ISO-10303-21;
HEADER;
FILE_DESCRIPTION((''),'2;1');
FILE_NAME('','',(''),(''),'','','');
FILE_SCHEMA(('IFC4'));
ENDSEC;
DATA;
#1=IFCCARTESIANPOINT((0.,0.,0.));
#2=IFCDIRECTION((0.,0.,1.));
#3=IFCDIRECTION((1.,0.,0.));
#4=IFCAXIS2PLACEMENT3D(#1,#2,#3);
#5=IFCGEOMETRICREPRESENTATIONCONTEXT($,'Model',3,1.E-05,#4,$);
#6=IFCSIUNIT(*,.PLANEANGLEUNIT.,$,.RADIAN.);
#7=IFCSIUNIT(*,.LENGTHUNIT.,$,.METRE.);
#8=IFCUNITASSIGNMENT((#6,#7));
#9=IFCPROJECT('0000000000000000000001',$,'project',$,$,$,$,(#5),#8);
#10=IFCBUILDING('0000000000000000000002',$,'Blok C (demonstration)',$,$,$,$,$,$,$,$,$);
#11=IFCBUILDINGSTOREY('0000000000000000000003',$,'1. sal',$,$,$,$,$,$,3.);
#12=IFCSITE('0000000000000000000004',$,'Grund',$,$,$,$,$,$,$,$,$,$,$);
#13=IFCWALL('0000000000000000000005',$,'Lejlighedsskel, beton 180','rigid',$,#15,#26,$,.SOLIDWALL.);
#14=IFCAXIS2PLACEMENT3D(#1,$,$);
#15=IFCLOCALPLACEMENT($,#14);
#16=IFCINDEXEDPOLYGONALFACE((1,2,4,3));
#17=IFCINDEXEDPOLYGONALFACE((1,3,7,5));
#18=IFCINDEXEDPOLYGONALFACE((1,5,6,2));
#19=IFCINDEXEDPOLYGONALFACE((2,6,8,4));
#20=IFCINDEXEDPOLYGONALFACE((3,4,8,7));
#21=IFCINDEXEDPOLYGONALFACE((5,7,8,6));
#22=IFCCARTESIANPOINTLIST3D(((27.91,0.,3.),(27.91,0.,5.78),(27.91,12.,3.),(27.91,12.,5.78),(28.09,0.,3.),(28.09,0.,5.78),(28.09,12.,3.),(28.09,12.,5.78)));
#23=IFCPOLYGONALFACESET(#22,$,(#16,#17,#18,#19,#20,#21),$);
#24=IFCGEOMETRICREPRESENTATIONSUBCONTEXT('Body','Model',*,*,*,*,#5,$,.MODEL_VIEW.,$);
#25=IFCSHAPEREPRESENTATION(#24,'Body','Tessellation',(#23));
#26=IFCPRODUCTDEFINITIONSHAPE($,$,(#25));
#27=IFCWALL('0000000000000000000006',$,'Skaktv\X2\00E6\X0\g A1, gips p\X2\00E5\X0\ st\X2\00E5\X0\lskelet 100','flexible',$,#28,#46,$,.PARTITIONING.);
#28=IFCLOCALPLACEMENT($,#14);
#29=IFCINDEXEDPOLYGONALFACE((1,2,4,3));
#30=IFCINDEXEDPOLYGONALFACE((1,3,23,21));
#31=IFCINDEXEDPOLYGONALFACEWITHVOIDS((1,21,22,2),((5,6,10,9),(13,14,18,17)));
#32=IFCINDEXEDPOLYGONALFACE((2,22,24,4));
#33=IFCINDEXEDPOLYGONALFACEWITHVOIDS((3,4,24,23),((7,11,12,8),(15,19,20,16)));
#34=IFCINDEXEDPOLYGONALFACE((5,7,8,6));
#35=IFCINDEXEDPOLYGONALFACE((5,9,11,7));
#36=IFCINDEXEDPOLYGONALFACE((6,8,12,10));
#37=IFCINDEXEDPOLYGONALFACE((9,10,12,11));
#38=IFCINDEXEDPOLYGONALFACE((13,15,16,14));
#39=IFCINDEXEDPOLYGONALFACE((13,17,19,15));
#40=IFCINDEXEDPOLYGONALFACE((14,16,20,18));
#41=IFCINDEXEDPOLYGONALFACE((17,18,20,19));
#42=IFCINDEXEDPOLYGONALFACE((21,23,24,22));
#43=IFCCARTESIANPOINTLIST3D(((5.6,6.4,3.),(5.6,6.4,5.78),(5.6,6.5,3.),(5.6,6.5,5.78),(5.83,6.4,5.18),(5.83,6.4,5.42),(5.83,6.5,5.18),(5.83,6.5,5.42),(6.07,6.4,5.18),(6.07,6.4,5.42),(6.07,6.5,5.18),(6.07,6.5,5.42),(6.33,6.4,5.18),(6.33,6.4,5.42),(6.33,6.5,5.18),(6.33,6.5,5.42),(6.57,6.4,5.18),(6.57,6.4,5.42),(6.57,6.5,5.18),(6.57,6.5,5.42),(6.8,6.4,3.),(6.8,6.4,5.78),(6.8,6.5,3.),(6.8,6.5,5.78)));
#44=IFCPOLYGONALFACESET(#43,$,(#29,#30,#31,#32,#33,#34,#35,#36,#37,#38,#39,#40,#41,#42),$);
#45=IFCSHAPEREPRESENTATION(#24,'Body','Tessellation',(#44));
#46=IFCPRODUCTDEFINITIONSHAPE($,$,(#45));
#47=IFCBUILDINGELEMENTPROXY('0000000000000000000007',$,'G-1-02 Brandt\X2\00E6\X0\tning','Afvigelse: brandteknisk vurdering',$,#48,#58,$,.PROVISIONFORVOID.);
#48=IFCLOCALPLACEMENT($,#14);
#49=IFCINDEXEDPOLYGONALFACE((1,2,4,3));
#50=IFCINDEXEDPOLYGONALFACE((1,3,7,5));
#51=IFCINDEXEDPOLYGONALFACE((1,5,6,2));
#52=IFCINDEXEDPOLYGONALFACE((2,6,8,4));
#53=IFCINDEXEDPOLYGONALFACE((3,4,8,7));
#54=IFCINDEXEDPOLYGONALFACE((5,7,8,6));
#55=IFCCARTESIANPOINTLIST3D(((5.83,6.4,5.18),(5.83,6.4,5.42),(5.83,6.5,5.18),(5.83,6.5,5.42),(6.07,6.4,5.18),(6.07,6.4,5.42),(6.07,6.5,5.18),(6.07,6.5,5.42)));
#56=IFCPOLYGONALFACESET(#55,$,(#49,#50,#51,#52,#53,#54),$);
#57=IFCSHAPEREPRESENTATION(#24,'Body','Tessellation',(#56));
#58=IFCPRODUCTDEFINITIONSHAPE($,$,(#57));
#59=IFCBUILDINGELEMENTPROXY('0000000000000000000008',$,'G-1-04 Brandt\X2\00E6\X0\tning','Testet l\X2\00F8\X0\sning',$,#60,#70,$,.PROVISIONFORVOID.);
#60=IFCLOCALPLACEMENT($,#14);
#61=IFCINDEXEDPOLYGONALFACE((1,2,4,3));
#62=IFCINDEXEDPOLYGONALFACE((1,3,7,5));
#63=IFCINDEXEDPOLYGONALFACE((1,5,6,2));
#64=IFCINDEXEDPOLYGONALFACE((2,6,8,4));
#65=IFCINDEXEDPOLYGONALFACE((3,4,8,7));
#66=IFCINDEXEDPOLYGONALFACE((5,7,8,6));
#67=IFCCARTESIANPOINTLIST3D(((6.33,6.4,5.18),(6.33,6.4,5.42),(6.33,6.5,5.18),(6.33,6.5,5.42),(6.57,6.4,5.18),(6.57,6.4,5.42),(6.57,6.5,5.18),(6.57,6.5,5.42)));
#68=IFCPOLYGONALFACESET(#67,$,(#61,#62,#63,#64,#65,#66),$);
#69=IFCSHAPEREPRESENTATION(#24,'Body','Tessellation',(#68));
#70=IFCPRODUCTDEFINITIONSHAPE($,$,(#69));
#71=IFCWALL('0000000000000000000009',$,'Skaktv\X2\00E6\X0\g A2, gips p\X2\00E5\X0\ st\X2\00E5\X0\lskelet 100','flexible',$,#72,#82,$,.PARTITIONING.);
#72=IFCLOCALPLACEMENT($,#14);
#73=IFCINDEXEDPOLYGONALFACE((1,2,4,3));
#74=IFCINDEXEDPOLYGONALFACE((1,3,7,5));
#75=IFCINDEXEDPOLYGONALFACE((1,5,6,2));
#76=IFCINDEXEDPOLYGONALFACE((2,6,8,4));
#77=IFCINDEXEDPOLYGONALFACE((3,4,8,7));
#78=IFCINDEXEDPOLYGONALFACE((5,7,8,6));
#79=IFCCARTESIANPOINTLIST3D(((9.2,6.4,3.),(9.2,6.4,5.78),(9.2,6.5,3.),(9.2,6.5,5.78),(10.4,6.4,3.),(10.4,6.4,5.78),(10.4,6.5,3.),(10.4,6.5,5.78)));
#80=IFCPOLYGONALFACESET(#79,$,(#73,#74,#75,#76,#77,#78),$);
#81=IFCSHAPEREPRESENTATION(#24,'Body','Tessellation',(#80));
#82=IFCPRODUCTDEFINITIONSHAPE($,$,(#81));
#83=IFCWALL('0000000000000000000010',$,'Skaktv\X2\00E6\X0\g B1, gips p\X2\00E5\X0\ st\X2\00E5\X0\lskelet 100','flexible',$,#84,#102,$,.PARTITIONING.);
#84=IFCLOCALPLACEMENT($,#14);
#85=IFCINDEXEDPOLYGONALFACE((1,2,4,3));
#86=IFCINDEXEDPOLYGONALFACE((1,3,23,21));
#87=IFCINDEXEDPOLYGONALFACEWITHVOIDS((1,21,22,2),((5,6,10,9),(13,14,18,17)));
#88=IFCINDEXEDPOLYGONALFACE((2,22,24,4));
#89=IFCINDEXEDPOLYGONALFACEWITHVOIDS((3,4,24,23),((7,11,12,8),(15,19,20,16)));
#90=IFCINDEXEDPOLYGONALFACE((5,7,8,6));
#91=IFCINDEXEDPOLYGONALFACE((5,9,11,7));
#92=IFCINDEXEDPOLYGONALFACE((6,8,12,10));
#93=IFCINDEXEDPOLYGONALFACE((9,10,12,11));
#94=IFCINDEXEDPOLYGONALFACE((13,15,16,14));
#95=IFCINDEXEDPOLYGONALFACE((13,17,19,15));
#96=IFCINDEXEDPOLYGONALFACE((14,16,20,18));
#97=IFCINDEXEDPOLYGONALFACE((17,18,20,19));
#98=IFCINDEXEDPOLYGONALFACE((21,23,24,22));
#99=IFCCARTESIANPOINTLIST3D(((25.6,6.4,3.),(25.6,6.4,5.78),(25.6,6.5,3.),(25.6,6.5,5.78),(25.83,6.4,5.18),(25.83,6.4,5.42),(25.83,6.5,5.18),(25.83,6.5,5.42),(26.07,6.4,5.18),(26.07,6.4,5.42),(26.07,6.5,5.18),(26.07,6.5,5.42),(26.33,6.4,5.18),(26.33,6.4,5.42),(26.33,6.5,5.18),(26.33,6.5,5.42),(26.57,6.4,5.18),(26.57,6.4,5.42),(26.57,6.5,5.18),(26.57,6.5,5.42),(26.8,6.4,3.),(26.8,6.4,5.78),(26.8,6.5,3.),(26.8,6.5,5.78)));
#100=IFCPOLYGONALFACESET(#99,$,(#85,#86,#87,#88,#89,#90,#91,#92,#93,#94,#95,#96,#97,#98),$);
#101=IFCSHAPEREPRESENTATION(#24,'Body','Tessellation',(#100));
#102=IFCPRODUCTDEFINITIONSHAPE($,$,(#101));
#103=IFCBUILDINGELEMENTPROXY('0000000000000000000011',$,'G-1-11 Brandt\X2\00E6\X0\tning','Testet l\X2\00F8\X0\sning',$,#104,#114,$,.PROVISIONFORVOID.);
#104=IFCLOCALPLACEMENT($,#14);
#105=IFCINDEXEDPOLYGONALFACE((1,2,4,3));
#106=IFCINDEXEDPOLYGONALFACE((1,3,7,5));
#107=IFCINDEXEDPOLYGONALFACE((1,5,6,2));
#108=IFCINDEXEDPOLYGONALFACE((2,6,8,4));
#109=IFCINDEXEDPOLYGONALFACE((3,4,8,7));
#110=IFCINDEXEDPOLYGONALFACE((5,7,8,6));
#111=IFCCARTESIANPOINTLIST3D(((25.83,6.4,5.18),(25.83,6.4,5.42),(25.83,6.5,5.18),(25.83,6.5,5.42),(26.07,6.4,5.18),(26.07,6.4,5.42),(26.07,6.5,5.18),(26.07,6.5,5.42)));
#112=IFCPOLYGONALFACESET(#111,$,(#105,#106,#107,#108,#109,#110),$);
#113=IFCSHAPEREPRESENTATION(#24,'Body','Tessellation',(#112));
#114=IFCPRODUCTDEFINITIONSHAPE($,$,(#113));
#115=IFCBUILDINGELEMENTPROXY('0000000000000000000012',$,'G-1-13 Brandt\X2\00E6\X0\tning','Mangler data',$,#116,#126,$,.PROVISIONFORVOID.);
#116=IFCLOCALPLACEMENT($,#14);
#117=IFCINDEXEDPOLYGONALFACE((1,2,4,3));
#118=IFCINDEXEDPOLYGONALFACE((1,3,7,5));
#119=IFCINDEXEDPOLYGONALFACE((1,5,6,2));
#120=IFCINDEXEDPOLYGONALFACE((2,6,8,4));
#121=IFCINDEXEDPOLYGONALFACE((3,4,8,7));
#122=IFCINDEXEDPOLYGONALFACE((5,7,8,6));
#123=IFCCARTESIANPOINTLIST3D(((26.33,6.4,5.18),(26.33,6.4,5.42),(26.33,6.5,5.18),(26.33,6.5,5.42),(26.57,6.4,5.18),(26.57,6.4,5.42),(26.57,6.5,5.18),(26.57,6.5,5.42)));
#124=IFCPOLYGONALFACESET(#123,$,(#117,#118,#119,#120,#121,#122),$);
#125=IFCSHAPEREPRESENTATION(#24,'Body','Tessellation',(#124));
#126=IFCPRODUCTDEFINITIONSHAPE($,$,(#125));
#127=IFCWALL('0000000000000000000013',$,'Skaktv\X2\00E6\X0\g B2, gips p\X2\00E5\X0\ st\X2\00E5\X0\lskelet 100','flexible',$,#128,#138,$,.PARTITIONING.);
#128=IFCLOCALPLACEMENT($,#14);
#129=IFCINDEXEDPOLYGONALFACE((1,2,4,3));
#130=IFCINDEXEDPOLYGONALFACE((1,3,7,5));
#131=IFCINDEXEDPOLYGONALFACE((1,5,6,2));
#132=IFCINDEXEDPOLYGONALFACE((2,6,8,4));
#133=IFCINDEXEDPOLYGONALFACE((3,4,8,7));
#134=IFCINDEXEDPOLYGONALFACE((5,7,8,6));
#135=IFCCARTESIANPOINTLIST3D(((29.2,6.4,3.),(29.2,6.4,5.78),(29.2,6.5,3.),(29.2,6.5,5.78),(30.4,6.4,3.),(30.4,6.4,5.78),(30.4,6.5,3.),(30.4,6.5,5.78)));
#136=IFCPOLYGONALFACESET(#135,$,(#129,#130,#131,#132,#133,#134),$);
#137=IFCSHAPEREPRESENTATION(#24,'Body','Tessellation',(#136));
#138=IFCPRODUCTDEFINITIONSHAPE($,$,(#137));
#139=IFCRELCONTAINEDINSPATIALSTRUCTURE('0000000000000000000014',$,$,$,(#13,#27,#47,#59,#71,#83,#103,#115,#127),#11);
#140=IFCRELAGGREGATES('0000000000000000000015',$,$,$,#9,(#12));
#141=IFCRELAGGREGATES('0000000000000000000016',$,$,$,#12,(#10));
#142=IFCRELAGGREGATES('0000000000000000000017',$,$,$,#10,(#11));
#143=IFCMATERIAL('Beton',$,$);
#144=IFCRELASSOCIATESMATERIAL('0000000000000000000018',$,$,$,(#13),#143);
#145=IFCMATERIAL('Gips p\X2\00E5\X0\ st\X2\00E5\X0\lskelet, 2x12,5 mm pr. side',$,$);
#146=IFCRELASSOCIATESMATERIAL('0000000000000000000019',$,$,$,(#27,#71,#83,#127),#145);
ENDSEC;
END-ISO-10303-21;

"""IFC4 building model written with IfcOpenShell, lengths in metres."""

from ifc_helpers import new_model, si_unit, frame, origin_with_axes, place, context, subcontext, project, spatial, polyline, outline, extrude, material, element, fill, save


model = new_model("IFC4")

# Units and contexts
model_context = context("Model", 3, precision=1e-05, world=origin_with_axes())
body_context = subcontext(model_context, "Body", "Model", "MODEL_VIEW")
ifc_project = project(units=[si_unit("PLANEANGLEUNIT", "RADIAN"), si_unit("LENGTHUNIT", "METRE")], contexts=[model_context])

# Site, building, storey
site = spatial("IfcSite", under=ifc_project, Name="Grund")
building = spatial("IfcBuilding", under=site, Name="Blok C (demonstration)")
storey = spatial("IfcBuildingStorey", under=building, Name="1. sal", Elevation=3.0)

# Wall
ifc_material_1 = material(Name="Beton")
wall_1_placement = place(None, origin_with_axes())
element("IfcWall", 1, at=wall_1_placement, inside=storey, material=ifc_material_1, Name="Lejlighedsskel, beton 180", Description="rigid", PredefinedType="SOLIDWALL", context=body_context, shape_type="SweptSolid", body=[
    extrude(outline(polyline([(27.91, 0.0), (28.09, 0.0), (28.09, 12.0), (27.91, 12.0), (27.91, 0.0)])), frame((0.0, 0.0, 3.0)), (0.0, 0.0, 1.0), 2.78),
])

# Wall, openings, building element proxies
ifc_material_2 = material(Name="Gips på stålskelet, 2x12,5 mm pr. side")
wall_2_placement = place(None, origin_with_axes())
wall_2 = element("IfcWall", 2, at=wall_2_placement, inside=storey, material=ifc_material_2, Name="Skaktvæg A1, gips på stålskelet 100", Description="flexible", PredefinedType="PARTITIONING", context=body_context, shape_type="SweptSolid", body=[
    extrude(outline(polyline([(5.6, 6.4), (6.8, 6.4), (6.8, 6.5), (5.6, 6.5), (5.6, 6.4)])), frame((0.0, 0.0, 3.0)), (0.0, 0.0, 1.0), 2.78),
])
opening_1_placement = place(wall_2_placement, origin_with_axes())
opening_1 = element("IfcOpeningElement", 3, at=opening_1_placement, cuts=wall_2, PredefinedType="OPENING", context=body_context, shape_type="SweptSolid", body=[
    extrude(outline(polyline([(5.83, 6.33), (6.07, 6.33), (6.07, 6.57), (5.83, 6.57), (5.83, 6.33)])), frame((0.0, 0.0, 5.18)), (0.0, 0.0, 1.0), 0.24),
])
opening_2_placement = place(wall_2_placement, origin_with_axes())
opening_2 = element("IfcOpeningElement", 4, at=opening_2_placement, cuts=wall_2, PredefinedType="OPENING", context=body_context, shape_type="SweptSolid", body=[
    extrude(outline(polyline([(6.33, 6.33), (6.57, 6.33), (6.57, 6.57), (6.33, 6.57), (6.33, 6.33)])), frame((0.0, 0.0, 5.18)), (0.0, 0.0, 1.0), 0.24),
])
proxy_1_placement = place(None, origin_with_axes())
proxy_1 = element("IfcBuildingElementProxy", 5, at=proxy_1_placement, inside=storey, Name="G-1-02 Brandtætning", Description="Afvigelse: brandteknisk vurdering", PredefinedType="PROVISIONFORVOID", context=body_context, shape_type="SweptSolid", body=[
    extrude(outline(polyline([(5.83, 6.4), (6.07, 6.4), (6.07, 6.5), (5.83, 6.5), (5.83, 6.4)])), frame((0.0, 0.0, 5.18)), (0.0, 0.0, 1.0), 0.24),
])
fill(opening_1, proxy_1)
proxy_2_placement = place(None, origin_with_axes())
proxy_2 = element("IfcBuildingElementProxy", 6, at=proxy_2_placement, inside=storey, Name="G-1-04 Brandtætning", Description="Testet løsning", PredefinedType="PROVISIONFORVOID", context=body_context, shape_type="SweptSolid", body=[
    extrude(outline(polyline([(6.33, 6.4), (6.57, 6.4), (6.57, 6.5), (6.33, 6.5), (6.33, 6.4)])), frame((0.0, 0.0, 5.18)), (0.0, 0.0, 1.0), 0.24),
])
fill(opening_2, proxy_2)

# Wall
wall_3_placement = place(None, origin_with_axes())
element("IfcWall", 7, at=wall_3_placement, inside=storey, material=ifc_material_2, Name="Skaktvæg A2, gips på stålskelet 100", Description="flexible", PredefinedType="PARTITIONING", context=body_context, shape_type="SweptSolid", body=[
    extrude(outline(polyline([(9.2, 6.4), (10.4, 6.4), (10.4, 6.5), (9.2, 6.5), (9.2, 6.4)])), frame((0.0, 0.0, 3.0)), (0.0, 0.0, 1.0), 2.78),
])

# Wall, openings, building element proxies
wall_4_placement = place(None, origin_with_axes())
wall_4 = element("IfcWall", 8, at=wall_4_placement, inside=storey, material=ifc_material_2, Name="Skaktvæg B1, gips på stålskelet 100", Description="flexible", PredefinedType="PARTITIONING", context=body_context, shape_type="SweptSolid", body=[
    extrude(outline(polyline([(25.6, 6.4), (26.8, 6.4), (26.8, 6.5), (25.6, 6.5), (25.6, 6.4)])), frame((0.0, 0.0, 3.0)), (0.0, 0.0, 1.0), 2.78),
])
opening_3_placement = place(wall_4_placement, origin_with_axes())
opening_3 = element("IfcOpeningElement", 9, at=opening_3_placement, cuts=wall_4, PredefinedType="OPENING", context=body_context, shape_type="SweptSolid", body=[
    extrude(outline(polyline([(25.83, 6.33), (26.07, 6.33), (26.07, 6.57), (25.83, 6.57), (25.83, 6.33)])), frame((0.0, 0.0, 5.18)), (0.0, 0.0, 1.0), 0.24),
])
opening_4_placement = place(wall_4_placement, origin_with_axes())
opening_4 = element("IfcOpeningElement", 10, at=opening_4_placement, cuts=wall_4, PredefinedType="OPENING", context=body_context, shape_type="SweptSolid", body=[
    extrude(outline(polyline([(26.33, 6.33), (26.57, 6.33), (26.57, 6.57), (26.33, 6.57), (26.33, 6.33)])), frame((0.0, 0.0, 5.18)), (0.0, 0.0, 1.0), 0.24),
])
proxy_3_placement = place(None, origin_with_axes())
proxy_3 = element("IfcBuildingElementProxy", 11, at=proxy_3_placement, inside=storey, Name="G-1-11 Brandtætning", Description="Testet løsning", PredefinedType="PROVISIONFORVOID", context=body_context, shape_type="SweptSolid", body=[
    extrude(outline(polyline([(25.83, 6.4), (26.07, 6.4), (26.07, 6.5), (25.83, 6.5), (25.83, 6.4)])), frame((0.0, 0.0, 5.18)), (0.0, 0.0, 1.0), 0.24),
])
fill(opening_3, proxy_3)
proxy_4_placement = place(None, origin_with_axes())
proxy_4 = element("IfcBuildingElementProxy", 12, at=proxy_4_placement, inside=storey, Name="G-1-13 Brandtætning", Description="Mangler data", PredefinedType="PROVISIONFORVOID", context=body_context, shape_type="SweptSolid", body=[
    extrude(outline(polyline([(26.33, 6.4), (26.57, 6.4), (26.57, 6.5), (26.33, 6.5), (26.33, 6.4)])), frame((0.0, 0.0, 5.18)), (0.0, 0.0, 1.0), 0.24),
])
fill(opening_4, proxy_4)

# Wall
wall_5_placement = place(None, origin_with_axes())
element("IfcWall", 13, at=wall_5_placement, inside=storey, material=ifc_material_2, Name="Skaktvæg B2, gips på stålskelet 100", Description="flexible", PredefinedType="PARTITIONING", context=body_context, shape_type="SweptSolid", body=[
    extrude(outline(polyline([(29.2, 6.4), (30.4, 6.4), (30.4, 6.5), (29.2, 6.5), (29.2, 6.4)])), frame((0.0, 0.0, 3.0)), (0.0, 0.0, 1.0), 2.78),
])

save(model, "model.ifc")
